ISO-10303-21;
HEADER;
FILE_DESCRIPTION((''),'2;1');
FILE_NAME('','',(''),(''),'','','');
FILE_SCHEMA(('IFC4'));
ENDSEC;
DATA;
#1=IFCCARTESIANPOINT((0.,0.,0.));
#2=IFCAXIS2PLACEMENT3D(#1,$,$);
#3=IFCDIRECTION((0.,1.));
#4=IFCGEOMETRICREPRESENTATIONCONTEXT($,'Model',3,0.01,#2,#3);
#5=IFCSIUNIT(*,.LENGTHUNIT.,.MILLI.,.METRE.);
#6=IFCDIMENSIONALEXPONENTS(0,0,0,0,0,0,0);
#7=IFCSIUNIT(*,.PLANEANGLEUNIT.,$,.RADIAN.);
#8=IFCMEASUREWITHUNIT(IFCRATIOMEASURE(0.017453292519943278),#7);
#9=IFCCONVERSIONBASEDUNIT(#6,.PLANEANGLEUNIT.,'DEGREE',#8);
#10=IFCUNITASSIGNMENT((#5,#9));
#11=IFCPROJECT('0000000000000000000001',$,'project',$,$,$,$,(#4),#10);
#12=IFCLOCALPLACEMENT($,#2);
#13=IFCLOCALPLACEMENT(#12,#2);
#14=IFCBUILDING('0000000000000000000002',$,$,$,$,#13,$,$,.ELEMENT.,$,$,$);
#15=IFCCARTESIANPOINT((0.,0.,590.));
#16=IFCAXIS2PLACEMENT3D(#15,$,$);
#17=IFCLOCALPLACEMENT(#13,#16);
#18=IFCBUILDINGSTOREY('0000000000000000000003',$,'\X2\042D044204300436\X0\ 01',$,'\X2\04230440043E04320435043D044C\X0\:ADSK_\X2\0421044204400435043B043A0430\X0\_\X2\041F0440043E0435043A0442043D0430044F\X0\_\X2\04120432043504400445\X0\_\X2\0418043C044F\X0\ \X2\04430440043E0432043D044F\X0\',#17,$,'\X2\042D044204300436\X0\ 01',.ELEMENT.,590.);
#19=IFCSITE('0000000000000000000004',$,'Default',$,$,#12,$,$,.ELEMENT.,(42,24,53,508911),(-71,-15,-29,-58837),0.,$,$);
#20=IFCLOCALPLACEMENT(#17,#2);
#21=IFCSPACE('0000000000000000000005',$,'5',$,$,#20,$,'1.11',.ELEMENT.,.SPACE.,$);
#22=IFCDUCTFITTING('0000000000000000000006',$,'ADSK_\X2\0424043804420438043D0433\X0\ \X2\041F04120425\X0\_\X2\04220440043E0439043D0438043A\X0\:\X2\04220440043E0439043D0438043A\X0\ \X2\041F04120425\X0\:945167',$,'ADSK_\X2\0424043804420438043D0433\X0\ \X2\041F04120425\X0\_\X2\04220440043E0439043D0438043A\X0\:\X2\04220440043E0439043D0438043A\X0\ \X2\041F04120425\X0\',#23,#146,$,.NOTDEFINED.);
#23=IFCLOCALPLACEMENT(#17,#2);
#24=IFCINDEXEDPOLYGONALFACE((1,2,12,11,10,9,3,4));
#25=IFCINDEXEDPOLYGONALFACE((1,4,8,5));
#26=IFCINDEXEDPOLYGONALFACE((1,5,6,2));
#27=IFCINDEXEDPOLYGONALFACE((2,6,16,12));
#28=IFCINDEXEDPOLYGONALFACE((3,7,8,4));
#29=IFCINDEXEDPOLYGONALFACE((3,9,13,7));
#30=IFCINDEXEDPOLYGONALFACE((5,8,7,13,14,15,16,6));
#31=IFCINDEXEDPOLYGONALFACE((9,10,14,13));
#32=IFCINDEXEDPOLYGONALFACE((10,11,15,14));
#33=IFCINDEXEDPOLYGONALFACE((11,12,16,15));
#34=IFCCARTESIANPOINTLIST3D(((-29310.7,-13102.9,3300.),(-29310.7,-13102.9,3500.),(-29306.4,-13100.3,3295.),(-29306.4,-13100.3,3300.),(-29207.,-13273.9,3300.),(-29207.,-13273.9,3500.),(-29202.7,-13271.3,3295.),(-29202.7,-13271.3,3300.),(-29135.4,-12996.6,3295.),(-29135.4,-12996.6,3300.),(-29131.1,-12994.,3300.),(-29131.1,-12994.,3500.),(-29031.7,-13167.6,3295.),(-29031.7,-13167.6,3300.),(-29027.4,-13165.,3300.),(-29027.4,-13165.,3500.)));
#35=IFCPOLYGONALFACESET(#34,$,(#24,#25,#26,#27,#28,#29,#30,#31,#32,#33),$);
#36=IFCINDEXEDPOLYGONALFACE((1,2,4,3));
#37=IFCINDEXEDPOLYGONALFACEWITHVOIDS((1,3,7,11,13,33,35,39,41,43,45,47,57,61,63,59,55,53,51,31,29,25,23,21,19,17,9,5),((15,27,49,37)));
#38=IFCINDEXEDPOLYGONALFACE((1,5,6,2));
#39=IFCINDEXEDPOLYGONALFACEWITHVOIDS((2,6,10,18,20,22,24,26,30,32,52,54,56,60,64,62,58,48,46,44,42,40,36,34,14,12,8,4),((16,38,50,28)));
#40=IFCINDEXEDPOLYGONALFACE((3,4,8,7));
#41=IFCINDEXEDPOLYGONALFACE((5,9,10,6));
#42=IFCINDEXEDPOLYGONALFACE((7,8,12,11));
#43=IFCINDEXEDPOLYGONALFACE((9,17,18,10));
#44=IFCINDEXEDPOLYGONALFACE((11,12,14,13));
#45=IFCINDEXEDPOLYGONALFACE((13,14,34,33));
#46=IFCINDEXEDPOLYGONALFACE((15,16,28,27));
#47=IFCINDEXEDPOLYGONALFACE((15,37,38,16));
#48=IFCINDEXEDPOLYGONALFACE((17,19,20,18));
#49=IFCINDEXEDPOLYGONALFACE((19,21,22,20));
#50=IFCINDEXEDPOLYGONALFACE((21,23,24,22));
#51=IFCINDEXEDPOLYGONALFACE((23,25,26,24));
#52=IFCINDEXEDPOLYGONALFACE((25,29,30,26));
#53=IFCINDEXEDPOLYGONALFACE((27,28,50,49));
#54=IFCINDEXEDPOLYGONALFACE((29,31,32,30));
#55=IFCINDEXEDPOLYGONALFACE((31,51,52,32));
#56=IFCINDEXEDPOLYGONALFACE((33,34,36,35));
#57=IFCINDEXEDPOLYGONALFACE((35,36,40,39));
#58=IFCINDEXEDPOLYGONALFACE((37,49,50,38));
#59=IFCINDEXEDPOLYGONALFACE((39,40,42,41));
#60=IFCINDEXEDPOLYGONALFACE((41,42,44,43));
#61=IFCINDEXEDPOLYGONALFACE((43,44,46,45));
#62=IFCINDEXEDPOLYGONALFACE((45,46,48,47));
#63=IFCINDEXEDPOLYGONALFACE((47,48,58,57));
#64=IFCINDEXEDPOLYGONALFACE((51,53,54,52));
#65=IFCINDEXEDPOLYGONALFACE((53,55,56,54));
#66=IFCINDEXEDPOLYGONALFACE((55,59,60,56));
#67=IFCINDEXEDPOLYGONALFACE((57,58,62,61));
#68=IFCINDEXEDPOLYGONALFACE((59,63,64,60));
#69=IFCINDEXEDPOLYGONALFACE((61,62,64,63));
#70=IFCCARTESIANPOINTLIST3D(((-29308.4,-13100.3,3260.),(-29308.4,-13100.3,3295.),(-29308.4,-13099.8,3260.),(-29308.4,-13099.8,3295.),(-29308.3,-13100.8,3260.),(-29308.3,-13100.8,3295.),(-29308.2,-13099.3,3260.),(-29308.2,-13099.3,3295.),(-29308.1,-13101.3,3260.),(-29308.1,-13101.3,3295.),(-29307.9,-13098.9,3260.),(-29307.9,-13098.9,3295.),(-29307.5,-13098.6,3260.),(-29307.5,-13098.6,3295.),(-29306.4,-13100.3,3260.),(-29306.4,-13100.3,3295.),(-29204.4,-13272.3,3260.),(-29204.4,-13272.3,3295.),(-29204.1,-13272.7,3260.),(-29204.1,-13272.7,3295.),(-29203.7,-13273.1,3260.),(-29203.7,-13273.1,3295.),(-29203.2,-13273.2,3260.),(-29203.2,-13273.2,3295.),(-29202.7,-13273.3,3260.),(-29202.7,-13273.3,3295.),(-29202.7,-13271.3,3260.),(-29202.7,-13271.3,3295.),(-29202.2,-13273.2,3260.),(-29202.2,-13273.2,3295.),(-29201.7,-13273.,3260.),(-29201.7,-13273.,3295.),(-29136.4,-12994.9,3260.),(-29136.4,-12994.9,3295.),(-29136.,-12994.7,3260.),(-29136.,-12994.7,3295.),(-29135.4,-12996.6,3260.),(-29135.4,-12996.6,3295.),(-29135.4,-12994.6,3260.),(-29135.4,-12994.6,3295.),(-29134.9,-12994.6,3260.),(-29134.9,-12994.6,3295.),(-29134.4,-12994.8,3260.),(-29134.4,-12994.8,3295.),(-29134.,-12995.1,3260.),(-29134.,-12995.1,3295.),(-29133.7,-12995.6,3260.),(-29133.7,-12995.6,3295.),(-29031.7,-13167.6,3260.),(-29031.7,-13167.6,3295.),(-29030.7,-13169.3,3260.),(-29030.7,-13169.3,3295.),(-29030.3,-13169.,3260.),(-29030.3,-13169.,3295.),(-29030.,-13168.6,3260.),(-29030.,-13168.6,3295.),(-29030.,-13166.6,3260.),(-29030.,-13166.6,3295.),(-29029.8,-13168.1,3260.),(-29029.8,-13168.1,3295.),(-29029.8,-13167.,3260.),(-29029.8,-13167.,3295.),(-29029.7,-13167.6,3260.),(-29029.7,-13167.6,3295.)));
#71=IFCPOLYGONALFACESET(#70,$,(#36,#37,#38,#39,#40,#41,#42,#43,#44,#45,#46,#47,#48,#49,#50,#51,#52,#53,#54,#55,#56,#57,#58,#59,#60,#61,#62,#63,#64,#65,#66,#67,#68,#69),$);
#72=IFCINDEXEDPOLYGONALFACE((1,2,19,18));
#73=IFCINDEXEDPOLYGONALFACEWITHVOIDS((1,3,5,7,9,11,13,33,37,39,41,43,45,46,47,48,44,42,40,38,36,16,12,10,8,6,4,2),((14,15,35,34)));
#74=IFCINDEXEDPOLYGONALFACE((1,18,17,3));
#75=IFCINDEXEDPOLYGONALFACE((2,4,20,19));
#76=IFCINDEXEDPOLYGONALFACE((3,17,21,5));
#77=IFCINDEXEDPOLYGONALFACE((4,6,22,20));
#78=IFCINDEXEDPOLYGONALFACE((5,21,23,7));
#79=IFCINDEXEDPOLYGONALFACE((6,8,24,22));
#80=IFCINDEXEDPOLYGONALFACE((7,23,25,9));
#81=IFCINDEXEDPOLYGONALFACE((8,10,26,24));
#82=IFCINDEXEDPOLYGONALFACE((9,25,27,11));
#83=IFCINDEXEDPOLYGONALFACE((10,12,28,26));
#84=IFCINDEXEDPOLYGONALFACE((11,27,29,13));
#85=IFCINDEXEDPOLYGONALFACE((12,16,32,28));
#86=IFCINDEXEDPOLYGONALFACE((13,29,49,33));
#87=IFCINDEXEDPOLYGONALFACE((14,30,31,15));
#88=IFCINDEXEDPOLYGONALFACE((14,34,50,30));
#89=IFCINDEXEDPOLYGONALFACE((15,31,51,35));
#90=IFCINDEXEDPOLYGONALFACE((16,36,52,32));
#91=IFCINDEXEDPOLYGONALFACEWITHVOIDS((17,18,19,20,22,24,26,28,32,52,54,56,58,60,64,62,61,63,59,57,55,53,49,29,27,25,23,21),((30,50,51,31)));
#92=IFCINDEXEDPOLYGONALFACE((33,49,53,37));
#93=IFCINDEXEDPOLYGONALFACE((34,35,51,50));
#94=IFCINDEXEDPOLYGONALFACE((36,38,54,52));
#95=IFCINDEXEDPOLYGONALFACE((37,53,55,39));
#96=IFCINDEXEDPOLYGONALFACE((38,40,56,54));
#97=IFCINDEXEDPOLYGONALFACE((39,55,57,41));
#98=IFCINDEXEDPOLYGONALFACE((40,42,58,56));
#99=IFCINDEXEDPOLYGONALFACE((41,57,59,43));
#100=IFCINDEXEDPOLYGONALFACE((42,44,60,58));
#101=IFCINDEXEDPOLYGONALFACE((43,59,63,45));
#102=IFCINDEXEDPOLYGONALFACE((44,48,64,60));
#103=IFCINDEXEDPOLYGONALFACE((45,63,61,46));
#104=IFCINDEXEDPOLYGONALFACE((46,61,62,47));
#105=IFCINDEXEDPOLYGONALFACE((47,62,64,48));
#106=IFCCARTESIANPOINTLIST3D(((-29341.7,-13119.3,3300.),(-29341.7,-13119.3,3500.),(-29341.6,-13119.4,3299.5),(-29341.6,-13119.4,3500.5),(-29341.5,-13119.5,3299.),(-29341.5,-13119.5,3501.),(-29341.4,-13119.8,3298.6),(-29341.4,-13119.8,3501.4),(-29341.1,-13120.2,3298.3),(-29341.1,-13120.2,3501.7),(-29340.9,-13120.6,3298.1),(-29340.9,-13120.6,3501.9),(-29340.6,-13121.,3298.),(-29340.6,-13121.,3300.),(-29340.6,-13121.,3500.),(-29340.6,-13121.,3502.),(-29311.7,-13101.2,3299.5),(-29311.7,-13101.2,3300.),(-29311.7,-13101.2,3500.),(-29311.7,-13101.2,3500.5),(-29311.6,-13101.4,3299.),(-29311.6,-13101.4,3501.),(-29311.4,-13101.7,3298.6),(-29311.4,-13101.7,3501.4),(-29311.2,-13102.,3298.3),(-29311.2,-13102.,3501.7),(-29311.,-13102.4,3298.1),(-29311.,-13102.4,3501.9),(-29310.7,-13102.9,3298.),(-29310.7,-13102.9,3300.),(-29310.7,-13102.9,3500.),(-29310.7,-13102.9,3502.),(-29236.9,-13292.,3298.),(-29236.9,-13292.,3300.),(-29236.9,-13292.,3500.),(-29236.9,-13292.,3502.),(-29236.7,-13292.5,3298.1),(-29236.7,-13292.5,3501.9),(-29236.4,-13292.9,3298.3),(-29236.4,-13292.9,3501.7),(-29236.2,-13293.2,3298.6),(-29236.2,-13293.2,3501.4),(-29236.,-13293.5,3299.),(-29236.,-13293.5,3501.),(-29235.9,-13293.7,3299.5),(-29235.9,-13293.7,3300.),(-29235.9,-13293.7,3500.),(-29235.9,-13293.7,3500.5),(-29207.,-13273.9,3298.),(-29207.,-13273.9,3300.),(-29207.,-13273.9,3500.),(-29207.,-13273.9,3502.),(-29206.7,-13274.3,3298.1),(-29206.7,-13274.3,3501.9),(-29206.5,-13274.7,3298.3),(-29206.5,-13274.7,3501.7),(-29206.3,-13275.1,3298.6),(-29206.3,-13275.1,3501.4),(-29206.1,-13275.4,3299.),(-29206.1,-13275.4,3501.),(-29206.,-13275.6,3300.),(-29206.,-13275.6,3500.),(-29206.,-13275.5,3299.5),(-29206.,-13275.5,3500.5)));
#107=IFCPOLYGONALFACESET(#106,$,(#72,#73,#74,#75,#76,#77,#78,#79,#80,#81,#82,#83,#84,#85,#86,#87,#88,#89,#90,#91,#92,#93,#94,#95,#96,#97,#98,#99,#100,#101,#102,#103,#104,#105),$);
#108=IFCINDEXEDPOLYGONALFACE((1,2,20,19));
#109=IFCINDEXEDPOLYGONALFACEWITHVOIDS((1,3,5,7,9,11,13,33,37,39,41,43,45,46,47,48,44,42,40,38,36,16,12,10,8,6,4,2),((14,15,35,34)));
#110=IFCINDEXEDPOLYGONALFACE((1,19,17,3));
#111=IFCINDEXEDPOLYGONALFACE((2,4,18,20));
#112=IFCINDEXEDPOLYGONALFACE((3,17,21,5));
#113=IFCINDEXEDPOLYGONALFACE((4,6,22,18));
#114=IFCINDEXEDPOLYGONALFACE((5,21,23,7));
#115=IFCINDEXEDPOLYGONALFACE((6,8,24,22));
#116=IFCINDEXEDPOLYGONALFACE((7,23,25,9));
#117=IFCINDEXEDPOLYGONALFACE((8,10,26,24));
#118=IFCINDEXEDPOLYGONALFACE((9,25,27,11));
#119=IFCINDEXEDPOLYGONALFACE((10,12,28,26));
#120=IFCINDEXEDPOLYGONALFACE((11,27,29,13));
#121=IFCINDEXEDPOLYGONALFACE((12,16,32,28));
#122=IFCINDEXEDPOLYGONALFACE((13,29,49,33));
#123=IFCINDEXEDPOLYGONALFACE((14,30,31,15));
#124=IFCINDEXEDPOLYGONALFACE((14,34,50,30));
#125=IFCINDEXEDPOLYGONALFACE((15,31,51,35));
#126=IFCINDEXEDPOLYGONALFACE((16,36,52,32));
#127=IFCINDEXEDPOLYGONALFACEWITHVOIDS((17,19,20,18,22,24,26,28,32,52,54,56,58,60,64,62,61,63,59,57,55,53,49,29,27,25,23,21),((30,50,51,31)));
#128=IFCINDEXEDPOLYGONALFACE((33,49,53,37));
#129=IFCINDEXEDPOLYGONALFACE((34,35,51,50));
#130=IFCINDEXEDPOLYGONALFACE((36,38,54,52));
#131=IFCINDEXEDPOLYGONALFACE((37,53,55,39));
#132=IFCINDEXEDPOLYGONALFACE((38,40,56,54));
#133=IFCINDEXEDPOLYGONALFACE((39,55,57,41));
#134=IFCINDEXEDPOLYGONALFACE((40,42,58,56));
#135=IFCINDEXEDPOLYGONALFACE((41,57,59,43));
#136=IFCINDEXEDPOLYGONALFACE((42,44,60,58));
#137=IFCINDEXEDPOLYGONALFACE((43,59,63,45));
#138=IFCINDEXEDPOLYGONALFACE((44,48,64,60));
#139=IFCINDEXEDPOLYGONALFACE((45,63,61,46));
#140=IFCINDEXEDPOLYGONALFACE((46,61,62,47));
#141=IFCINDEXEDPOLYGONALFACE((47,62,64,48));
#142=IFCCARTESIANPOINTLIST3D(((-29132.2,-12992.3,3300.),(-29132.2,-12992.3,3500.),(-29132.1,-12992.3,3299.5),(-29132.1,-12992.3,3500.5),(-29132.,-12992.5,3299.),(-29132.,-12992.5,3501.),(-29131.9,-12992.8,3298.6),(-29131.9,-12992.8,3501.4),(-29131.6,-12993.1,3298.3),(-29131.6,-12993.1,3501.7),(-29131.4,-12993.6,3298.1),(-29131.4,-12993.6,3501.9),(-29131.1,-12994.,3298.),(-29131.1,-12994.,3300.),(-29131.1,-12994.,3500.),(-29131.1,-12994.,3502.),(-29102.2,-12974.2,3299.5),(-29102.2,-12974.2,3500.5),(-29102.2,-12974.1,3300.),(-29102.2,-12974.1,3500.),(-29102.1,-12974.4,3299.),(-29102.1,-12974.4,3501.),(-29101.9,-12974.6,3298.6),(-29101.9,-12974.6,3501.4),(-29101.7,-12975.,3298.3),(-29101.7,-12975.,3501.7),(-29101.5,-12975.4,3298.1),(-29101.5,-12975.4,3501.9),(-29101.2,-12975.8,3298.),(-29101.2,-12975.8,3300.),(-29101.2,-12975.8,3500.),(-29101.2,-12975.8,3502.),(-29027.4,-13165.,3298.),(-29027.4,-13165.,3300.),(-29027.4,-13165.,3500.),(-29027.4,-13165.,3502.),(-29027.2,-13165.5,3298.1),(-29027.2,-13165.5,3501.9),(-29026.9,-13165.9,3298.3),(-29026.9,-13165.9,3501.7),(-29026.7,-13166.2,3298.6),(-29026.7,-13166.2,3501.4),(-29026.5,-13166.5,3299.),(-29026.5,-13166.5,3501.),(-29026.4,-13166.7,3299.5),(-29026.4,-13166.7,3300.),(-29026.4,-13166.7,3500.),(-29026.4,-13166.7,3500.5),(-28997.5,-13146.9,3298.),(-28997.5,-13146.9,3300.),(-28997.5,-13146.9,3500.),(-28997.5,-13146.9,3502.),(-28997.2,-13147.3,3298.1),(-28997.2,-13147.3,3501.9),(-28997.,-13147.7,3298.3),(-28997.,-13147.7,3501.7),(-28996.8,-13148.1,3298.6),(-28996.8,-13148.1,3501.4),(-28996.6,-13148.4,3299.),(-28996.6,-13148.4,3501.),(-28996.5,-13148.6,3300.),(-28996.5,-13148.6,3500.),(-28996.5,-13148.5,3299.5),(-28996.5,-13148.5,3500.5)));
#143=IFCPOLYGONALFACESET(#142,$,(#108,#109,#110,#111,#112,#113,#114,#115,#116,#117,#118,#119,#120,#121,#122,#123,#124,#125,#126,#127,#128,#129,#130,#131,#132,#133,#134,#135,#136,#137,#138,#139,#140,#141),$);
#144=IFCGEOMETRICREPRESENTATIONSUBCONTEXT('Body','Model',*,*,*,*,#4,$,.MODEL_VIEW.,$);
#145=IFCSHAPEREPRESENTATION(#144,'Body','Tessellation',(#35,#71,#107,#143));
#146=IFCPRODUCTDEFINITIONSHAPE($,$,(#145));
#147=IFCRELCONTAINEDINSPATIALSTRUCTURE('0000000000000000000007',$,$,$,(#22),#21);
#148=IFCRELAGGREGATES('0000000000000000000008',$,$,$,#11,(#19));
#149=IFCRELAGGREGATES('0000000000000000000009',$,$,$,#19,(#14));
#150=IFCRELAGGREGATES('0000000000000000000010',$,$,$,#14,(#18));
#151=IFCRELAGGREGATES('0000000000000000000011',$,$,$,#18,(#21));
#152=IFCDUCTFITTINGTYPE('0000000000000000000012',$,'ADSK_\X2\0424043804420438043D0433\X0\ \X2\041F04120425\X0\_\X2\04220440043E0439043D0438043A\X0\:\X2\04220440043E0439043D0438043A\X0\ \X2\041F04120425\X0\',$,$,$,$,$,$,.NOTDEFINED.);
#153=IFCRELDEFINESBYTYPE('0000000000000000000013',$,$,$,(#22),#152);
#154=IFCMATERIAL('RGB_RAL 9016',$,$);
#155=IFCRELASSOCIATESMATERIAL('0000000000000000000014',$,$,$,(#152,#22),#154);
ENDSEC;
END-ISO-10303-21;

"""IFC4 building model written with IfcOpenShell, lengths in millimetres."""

from ifc_helpers import new_model, entity, si_unit, converted_unit, direction, frame, frame_2d, origin, place, context, subcontext, project, spatial, polyline, circle_curve, parameter, trimmed, segment, composite_curve, outline, extrude, source, transform, mapped, material, type_object, type_shapes, element, save


model = new_model("IFC4")

# Units and contexts
model_context = context("Model", 3, precision=0.01, world=origin(), true_north=direction((0.0, 1.0)))
body_context = subcontext(model_context, "Body", "Model", "MODEL_VIEW")
ifc_project = project(units=[si_unit("LENGTHUNIT", "METRE", prefix="MILLI"), converted_unit("PLANEANGLEUNIT", "DEGREE", entity("IfcRatioMeasure", 0.017453292519943278), si_unit("PLANEANGLEUNIT", "RADIAN"), dimensions=[0, 0, 0, 0, 0, 0, 0])], contexts=[model_context])

# Site, building, storey
site_placement = place(None, origin())
site = spatial("IfcSite", under=ifc_project, at=site_placement, Name="Default", CompositionType="ELEMENT", RefLatitude=(42, 24, 53, 508911), RefLongitude=(-71, -15, -29, -58837), RefElevation=0.0)
building_placement = place(site_placement, origin())
building = spatial("IfcBuilding", under=site, at=building_placement, CompositionType="ELEMENT")
storey_placement = place(building_placement, frame((0.0, 0.0, 590.0)))
storey = spatial("IfcBuildingStorey", under=building, at=storey_placement, Name="Этаж 01", ObjectType="Уровень:ADSK_Стрелка_Проектная_Вверх_Имя уровня", LongName="Этаж 01", CompositionType="ELEMENT", Elevation=590.0)

# Shared definitions
space_1_placement = place(storey_placement, origin())
space_1 = spatial("IfcSpace", under=storey, at=space_1_placement, Name="5", LongName="1.11", CompositionType="ELEMENT", PredefinedType="SPACE")

# Duct fitting
ifc_material_1 = material(Name="RGB_RAL 9016")
duct_fitting_type_1 = type_object("IfcDuctFittingType", Name="ADSK_Фитинг ПВХ_Тройник:Тройник ПВХ", PredefinedType="NOTDEFINED", material=ifc_material_1)
shared_shape_1 = source(origin(), body_context, "Body", "SweptSolid", [
    extrude(outline(polyline([(-105.0, -151.2), (105.0, -151.2), (105.0, 48.7), (100.0, 48.7), (100.0, 53.8), (-100.0, 53.8), (-100.0, 48.7), (-105.0, 48.7), (-105.0, -151.2)])), frame((0.0, -51.3, -100.0), z_axis=(0.0, 0.0, 1.0), x_axis=(-1.0, 0.0, 0.0)), (0.0, 0.0, 1.0), 200.0),
    extrude(outline(composite_curve([segment(trimmed(circle_curve(frame_2d((100.0, -100.0), x_axis=(1.0, 0.0)), 2.0), [parameter(270.0)], [parameter(0.0)], True, "PARAMETER"), True, "CONTINUOUS"), segment(polyline([(102.0, -100.0), (102.0, 100.0)]), True, "CONTINUOUS"), segment(trimmed(circle_curve(frame_2d((100.0, 100.0), x_axis=(1.0, 0.0)), 2.0), [parameter(0.0)], [parameter(90.0)], True, "PARAMETER"), True, "CONTINUOUS"), segment(polyline([(100.0, 102.0), (-100.0, 102.0)]), True, "CONTINUOUS"), segment(trimmed(circle_curve(frame_2d((-100.0, 100.0), x_axis=(1.0, 0.0)), 2.0), [parameter(90.0)], [parameter(180.0)], True, "PARAMETER"), True, "CONTINUOUS"), segment(polyline([(-102.0, 100.0), (-102.0, -100.0)]), True, "CONTINUOUS"), segment(trimmed(circle_curve(frame_2d((-100.0, -100.0), x_axis=(1.0, 0.0)), 2.0), [parameter(180.0)], [parameter(270.0)], True, "PARAMETER"), True, "CONTINUOUS"), segment(polyline([(-100.0, -102.0), (100.0, -102.0)]), True, "CONTINUOUS")], self_intersect=False), holes=[polyline([(100.0, -100.0), (-100.0, -100.0), (-100.0, 100.0), (100.0, 100.0), (100.0, -100.0)])]), frame((0.0, -140.0, 0.0), z_axis=(0.0, 1.0, 0.0), x_axis=(1.0, 0.0, 0.0)), (0.0, 0.0, 1.0), 35.0),
    extrude(outline(composite_curve([segment(trimmed(circle_curve(frame_2d((-100.0, 100.0), x_axis=(1.0, 0.0)), 2.0), [parameter(90.0)], [parameter(180.0)], True, "PARAMETER"), True, "CONTINUOUS"), segment(polyline([(-102.0, 100.0), (-102.0, -100.0)]), True, "CONTINUOUS"), segment(trimmed(circle_curve(frame_2d((-100.0, -100.0), x_axis=(1.0, 0.0)), 2.0), [parameter(180.0)], [parameter(270.0)], True, "PARAMETER"), True, "CONTINUOUS"), segment(polyline([(-100.0, -102.0), (100.0, -102.0)]), True, "CONTINUOUS"), segment(trimmed(circle_curve(frame_2d((100.0, -100.0), x_axis=(1.0, 0.0)), 2.0), [parameter(270.0)], [parameter(0.0)], True, "PARAMETER"), True, "CONTINUOUS"), segment(polyline([(102.0, -100.0), (102.0, 100.0)]), True, "CONTINUOUS"), segment(trimmed(circle_curve(frame_2d((100.0, 100.0), x_axis=(1.0, 0.0)), 2.0), [parameter(0.0)], [parameter(90.0)], True, "PARAMETER"), True, "CONTINUOUS"), segment(polyline([(100.0, 102.0), (-100.0, 102.0)]), True, "CONTINUOUS")], self_intersect=False), holes=[polyline([(-100.0, 100.0), (100.0, 100.0), (100.0, -100.0), (-100.0, -100.0), (-100.0, 100.0)])]), frame((105.0, 0.0, 0.0), z_axis=(1.0, 0.0, 0.0), x_axis=(0.0, 1.0, 0.0)), (0.0, 0.0, 1.0), 35.0),
    extrude(outline(composite_curve([segment(trimmed(circle_curve(frame_2d((-100.0, 100.0), x_axis=(1.0, 0.0)), 2.0), [parameter(90.0)], [parameter(180.0)], True, "PARAMETER"), True, "CONTINUOUS"), segment(polyline([(-102.0, 100.0), (-102.0, -100.0)]), True, "CONTINUOUS"), segment(trimmed(circle_curve(frame_2d((-100.0, -100.0), x_axis=(1.0, 0.0)), 2.0), [parameter(180.0)], [parameter(270.0)], True, "PARAMETER"), True, "CONTINUOUS"), segment(polyline([(-100.0, -102.0), (100.0, -102.0)]), True, "CONTINUOUS"), segment(trimmed(circle_curve(frame_2d((100.0, -100.0), x_axis=(1.0, 0.0)), 2.0), [parameter(270.0)], [parameter(0.0)], True, "PARAMETER"), True, "CONTINUOUS"), segment(polyline([(102.0, -100.0), (102.0, 100.0)]), True, "CONTINUOUS"), segment(trimmed(circle_curve(frame_2d((100.0, 100.0), x_axis=(1.0, 0.0)), 2.0), [parameter(0.0)], [parameter(90.0)], True, "PARAMETER"), True, "CONTINUOUS"), segment(polyline([(100.0, 102.0), (-100.0, 102.0)]), True, "CONTINUOUS")], self_intersect=False), holes=[polyline([(-100.0, 100.0), (100.0, 100.0), (100.0, -100.0), (-100.0, -100.0), (-100.0, 100.0)])]), frame((-140.0, 0.0, 0.0), z_axis=(1.0, 0.0, 0.0), x_axis=(0.0, 1.0, 0.0)), (0.0, 0.0, 1.0), 35.0),
])
type_shapes(duct_fitting_type_1, [shared_shape_1])
duct_fitting_1_placement = place(space_1_placement, frame((-29169.1, -13133.9, 3400.0), z_axis=(-0.51846, 0.855102, 0.0), x_axis=(-0.855102, -0.51846, 0.0)))
element("IfcDuctFitting", 1, at=duct_fitting_1_placement, inside=space_1, type_object=duct_fitting_type_1, material=ifc_material_1, Name="ADSK_Фитинг ПВХ_Тройник:Тройник ПВХ:945167", ObjectType="ADSK_Фитинг ПВХ_Тройник:Тройник ПВХ", PredefinedType="NOTDEFINED", context=body_context, shape_type="MappedRepresentation", body=[
    mapped(shared_shape_1, transform((0.0, 0.0, 0.0), scale=1.0)),
])

save(model, "model.ifc")
